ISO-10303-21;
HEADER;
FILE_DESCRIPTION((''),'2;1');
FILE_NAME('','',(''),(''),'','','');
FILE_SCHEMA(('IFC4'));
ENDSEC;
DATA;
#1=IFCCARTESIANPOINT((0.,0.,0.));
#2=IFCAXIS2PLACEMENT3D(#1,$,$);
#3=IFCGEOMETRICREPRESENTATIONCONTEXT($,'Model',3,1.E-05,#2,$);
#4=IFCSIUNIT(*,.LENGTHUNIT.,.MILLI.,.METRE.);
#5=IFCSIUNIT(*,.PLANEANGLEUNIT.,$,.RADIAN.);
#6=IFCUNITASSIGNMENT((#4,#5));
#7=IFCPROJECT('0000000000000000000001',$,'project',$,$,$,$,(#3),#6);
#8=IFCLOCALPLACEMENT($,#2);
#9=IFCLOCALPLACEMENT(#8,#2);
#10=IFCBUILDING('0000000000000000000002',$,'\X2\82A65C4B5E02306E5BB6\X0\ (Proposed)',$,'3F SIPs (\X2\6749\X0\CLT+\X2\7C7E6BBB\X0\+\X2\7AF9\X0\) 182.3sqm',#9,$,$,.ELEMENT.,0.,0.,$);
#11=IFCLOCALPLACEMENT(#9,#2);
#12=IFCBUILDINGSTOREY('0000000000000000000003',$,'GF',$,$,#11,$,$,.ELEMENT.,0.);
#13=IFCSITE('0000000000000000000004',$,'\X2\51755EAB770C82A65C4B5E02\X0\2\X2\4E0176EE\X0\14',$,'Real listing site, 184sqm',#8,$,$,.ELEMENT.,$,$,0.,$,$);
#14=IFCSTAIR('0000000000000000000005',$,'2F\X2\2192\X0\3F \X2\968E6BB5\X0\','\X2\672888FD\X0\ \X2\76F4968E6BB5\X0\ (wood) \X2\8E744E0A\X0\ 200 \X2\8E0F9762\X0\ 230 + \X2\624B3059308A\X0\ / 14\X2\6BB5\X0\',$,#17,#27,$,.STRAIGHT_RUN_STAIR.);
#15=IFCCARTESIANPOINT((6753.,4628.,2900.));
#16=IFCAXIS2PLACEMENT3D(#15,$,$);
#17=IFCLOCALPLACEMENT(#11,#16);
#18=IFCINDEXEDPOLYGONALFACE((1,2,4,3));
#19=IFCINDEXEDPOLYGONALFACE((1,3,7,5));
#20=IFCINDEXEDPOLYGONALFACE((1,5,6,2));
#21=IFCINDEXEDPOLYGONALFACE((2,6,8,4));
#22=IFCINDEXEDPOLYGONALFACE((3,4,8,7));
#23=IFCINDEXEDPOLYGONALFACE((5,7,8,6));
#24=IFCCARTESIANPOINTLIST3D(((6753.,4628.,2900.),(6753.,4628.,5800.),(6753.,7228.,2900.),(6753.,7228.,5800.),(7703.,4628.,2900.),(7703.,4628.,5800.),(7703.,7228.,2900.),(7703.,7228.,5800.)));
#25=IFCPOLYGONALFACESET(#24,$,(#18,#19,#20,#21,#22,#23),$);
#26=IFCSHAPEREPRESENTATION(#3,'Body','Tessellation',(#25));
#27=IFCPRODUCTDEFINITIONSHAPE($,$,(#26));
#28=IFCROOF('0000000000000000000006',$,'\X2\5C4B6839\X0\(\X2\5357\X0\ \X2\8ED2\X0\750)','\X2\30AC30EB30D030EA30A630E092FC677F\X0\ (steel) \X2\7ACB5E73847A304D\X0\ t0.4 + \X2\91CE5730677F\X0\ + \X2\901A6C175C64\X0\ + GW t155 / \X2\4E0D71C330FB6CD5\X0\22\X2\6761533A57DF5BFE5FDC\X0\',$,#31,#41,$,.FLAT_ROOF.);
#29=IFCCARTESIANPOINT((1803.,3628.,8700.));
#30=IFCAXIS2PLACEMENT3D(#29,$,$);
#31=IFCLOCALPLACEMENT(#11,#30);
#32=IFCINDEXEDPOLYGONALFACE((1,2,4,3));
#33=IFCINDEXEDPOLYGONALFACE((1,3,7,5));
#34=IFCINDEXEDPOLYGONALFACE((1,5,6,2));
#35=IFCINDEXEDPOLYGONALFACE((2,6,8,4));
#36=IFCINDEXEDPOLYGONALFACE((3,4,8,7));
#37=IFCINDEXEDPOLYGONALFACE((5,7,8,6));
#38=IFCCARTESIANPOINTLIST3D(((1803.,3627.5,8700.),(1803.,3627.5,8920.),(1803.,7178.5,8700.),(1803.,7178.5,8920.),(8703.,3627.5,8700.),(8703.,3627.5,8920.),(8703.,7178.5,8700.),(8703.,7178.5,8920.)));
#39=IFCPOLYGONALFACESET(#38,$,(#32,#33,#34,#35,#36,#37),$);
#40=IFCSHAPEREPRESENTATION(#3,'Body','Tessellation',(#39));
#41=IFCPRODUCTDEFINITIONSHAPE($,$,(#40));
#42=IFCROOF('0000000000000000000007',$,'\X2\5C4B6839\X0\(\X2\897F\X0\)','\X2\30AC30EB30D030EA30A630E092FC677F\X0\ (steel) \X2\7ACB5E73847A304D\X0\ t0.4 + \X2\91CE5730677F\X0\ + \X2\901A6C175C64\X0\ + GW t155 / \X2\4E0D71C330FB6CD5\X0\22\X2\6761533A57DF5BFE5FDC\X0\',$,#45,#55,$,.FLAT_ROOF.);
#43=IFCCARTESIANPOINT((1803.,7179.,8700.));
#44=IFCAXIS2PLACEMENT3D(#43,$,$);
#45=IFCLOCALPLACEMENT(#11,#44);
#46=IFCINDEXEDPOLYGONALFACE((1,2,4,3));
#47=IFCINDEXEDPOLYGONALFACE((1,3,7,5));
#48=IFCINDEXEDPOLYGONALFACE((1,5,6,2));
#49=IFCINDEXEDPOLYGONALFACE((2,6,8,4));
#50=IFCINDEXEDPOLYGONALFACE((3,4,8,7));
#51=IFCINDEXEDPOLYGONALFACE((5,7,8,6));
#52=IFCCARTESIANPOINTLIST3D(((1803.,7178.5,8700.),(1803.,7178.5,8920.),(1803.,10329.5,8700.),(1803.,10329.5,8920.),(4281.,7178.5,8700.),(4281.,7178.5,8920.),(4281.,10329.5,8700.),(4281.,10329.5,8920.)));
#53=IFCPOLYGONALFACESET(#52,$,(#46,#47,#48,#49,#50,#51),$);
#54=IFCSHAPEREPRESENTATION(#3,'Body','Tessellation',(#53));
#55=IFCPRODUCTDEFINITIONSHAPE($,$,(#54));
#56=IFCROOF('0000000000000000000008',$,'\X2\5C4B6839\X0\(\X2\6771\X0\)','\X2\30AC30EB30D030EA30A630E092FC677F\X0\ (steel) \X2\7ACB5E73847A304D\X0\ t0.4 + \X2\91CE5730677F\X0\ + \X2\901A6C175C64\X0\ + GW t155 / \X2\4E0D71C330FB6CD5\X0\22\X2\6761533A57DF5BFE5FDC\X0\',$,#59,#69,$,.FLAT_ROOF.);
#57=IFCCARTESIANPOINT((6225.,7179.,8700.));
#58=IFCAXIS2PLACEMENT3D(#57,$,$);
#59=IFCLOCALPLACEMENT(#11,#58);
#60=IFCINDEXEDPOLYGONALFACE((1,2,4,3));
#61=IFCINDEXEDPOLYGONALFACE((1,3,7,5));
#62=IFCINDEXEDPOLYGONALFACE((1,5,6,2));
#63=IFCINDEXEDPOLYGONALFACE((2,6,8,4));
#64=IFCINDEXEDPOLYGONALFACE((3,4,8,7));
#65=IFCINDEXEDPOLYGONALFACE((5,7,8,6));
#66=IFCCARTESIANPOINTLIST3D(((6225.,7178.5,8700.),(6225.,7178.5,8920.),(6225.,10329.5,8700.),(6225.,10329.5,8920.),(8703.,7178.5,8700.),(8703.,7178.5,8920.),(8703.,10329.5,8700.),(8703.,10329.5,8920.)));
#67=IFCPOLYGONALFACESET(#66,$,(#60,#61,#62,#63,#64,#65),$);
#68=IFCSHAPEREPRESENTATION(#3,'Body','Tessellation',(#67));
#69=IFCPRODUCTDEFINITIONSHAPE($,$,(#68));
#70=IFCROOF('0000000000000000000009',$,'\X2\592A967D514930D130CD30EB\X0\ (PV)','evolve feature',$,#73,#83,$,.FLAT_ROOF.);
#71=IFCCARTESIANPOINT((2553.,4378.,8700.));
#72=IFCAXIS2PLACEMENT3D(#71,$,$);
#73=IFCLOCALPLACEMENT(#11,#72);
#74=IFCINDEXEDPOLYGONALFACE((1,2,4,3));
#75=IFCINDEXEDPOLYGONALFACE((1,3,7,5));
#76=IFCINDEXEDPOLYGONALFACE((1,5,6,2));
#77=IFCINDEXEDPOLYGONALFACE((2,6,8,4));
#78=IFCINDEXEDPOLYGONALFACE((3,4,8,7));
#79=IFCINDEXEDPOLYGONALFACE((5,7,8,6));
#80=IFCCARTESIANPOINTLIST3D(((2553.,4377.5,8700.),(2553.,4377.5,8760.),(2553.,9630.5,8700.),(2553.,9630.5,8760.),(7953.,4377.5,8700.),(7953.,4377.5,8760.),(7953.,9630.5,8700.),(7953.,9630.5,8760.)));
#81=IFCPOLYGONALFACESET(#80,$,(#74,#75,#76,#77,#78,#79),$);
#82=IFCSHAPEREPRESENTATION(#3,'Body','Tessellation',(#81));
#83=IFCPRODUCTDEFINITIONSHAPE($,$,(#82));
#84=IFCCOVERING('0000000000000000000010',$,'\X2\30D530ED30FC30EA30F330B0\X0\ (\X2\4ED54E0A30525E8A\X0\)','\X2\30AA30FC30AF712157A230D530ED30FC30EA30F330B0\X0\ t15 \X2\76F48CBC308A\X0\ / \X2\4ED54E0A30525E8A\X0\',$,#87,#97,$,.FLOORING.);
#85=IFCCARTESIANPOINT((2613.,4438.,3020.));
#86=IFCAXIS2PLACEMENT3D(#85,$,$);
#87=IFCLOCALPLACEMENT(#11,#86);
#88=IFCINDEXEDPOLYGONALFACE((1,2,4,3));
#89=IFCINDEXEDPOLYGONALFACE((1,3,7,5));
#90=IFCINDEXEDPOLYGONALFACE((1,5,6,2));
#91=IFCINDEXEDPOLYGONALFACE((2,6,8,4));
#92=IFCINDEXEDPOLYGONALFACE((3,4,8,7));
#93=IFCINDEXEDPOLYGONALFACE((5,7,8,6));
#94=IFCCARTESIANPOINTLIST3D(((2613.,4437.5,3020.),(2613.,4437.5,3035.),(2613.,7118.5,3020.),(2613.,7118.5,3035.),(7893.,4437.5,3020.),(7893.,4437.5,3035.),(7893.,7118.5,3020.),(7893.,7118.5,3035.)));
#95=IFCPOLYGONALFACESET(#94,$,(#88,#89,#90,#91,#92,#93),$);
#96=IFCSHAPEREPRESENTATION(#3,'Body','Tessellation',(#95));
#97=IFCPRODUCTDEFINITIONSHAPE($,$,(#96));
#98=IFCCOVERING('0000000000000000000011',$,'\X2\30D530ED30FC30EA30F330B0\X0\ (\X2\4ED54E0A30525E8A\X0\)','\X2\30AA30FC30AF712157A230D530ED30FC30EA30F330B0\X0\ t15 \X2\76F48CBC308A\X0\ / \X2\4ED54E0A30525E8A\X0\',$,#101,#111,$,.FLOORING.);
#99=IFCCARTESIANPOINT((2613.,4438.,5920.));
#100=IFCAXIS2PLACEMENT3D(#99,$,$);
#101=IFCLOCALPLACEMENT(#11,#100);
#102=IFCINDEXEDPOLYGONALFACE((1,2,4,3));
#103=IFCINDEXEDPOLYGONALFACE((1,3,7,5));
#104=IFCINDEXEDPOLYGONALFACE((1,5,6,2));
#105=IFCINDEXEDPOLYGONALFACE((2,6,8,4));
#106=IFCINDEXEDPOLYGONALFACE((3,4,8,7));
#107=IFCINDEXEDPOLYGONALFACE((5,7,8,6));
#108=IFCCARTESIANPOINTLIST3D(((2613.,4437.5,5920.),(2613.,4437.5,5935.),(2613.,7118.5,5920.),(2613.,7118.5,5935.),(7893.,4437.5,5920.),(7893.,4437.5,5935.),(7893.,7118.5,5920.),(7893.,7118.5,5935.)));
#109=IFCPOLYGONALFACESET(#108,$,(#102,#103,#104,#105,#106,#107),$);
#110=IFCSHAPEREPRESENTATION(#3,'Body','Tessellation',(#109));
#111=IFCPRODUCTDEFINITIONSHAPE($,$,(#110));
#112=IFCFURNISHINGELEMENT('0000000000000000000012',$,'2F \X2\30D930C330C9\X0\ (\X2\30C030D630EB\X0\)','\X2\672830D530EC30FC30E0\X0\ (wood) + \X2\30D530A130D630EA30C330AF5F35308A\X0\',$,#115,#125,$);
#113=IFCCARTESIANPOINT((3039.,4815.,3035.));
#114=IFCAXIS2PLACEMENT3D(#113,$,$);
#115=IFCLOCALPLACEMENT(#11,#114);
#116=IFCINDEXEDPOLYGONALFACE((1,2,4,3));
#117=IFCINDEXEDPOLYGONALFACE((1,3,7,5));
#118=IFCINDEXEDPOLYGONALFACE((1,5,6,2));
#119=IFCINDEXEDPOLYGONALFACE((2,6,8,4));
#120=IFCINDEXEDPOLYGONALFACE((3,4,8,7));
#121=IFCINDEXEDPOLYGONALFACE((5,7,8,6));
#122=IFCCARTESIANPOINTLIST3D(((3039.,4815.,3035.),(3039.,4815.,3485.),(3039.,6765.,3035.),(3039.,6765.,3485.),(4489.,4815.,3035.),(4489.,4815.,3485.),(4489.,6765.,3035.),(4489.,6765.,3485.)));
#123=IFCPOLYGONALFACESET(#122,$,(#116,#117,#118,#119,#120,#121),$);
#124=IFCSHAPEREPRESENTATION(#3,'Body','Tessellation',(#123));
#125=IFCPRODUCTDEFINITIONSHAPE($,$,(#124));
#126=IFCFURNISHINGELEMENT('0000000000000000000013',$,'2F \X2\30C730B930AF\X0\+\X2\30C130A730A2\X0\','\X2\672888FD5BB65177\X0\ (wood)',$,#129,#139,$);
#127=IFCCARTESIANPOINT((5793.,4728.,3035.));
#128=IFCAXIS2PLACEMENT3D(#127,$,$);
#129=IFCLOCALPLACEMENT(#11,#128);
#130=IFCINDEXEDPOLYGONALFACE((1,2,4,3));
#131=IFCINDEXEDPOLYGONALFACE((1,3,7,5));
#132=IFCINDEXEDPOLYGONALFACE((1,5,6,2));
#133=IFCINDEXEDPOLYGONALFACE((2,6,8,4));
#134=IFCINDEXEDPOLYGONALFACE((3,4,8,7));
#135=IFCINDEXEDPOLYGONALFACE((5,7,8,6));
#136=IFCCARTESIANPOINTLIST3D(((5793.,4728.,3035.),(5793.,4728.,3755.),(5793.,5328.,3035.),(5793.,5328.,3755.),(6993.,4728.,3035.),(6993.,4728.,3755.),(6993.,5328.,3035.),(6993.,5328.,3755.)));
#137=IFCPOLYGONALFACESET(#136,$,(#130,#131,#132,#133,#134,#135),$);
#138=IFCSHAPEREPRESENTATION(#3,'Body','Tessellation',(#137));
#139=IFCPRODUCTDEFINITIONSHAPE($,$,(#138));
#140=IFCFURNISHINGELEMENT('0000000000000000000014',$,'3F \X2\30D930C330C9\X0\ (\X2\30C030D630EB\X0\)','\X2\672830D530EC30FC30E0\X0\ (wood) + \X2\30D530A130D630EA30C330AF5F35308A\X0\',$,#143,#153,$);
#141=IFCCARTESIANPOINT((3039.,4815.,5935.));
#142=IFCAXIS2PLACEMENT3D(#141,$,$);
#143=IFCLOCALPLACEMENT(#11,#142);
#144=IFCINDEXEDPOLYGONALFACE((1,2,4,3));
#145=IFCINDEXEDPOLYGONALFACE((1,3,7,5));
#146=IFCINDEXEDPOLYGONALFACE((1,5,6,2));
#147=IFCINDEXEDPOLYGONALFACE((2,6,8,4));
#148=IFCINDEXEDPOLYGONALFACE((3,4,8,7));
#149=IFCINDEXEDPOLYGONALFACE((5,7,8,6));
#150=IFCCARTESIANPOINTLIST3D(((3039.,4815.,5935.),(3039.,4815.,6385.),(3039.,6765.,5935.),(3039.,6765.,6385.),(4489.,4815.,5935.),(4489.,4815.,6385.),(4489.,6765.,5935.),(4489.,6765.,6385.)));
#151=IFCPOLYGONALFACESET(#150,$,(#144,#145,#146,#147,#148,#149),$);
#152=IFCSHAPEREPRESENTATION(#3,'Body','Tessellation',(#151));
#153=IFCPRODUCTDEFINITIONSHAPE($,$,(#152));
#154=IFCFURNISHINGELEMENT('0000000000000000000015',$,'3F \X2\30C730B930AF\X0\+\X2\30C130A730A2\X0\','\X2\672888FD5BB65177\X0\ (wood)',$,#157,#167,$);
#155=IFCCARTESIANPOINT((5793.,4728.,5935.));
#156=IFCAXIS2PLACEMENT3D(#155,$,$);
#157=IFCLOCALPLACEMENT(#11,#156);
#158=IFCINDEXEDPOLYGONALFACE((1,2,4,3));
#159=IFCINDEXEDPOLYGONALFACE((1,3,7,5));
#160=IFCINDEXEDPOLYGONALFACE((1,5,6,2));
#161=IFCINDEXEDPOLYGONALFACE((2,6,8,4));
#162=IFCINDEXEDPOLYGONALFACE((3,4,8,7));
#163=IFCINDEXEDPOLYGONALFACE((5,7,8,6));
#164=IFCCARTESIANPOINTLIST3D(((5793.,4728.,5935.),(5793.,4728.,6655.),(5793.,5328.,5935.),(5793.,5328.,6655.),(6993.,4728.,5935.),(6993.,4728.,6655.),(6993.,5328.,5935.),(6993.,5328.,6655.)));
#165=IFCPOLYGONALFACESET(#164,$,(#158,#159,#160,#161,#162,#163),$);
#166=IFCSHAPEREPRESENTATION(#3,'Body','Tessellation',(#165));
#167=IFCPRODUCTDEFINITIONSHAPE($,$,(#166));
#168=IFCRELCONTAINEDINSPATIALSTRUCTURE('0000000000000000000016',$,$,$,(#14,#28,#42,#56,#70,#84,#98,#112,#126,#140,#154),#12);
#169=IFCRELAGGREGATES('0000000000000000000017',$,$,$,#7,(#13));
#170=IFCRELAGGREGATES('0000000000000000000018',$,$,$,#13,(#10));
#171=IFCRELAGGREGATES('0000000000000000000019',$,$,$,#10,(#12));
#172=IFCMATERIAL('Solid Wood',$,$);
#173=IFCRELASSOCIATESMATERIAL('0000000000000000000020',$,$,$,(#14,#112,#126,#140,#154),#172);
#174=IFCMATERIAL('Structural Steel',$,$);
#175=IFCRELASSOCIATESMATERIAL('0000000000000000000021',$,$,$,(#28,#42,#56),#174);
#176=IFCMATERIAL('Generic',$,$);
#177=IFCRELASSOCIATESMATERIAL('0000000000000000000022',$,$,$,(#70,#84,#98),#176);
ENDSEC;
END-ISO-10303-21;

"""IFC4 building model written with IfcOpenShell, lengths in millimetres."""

from ifc_helpers import new_model, si_unit, frame, frame_2d, origin, place, context, project, spatial, rectangle, extrude, material, element, save


model = new_model("IFC4")

# Units and contexts
model_context = context("Model", 3, precision=1e-05, world=origin())
ifc_project = project(units=[si_unit("LENGTHUNIT", "METRE", prefix="MILLI"), si_unit("PLANEANGLEUNIT", "RADIAN")], contexts=[model_context])

# Site, building, storey
site_placement = place(None, origin())
site = spatial("IfcSite", under=ifc_project, at=site_placement, Name="兵庫県芦屋市2丁目14", ObjectType="Real listing site, 184sqm", CompositionType="ELEMENT", RefElevation=0.0)
building_placement = place(site_placement, origin())
building = spatial("IfcBuilding", under=site, at=building_placement, Name="芦屋市の家 (Proposed)", ObjectType="3F SIPs (杉CLT+籾殻+竹) 182.3sqm", CompositionType="ELEMENT", ElevationOfRefHeight=0.0, ElevationOfTerrain=0.0)
storey_placement = place(building_placement, origin())
storey = spatial("IfcBuildingStorey", under=building, at=storey_placement, Name="GF", CompositionType="ELEMENT", Elevation=0.0)

# Shared definitions
ifc_material_1 = material(Name="Solid Wood")

# Stair
stair_placement = place(storey_placement, frame((6753.0, 4628.0, 2900.0)))
element("IfcStair", 1, at=stair_placement, inside=storey, material=ifc_material_1, Name="2F→3F 階段", Description="木製 直階段 (wood) 蹴上 200 踏面 230 + 手すり / 14段", PredefinedType="STRAIGHT_RUN_STAIR", context=model_context, shape_type="SweptSolid", body=[
    extrude(rectangle(XDim=950.0, YDim=2600.0, at=frame_2d((475.0, 1300.0))), frame((6753.0, 4628.0, 2900.0)), (0.0, 0.0, 1.0), 2900.0),
])

# Roofs
ifc_material_2 = material(Name="Structural Steel")
roof_1_placement = place(storey_placement, frame((1803.0, 3628.0, 8700.0)))
element("IfcRoof", 2, at=roof_1_placement, inside=storey, material=ifc_material_2, Name="屋根(南 軒750)", Description="ガルバリウム鋼板 (steel) 立平葺き t0.4 + 野地板 + 通気層 + GW t155 / 不燃・法22条区域対応", PredefinedType="FLAT_ROOF", context=model_context, shape_type="SweptSolid", body=[
    extrude(rectangle(XDim=6900.0, YDim=3551.0, at=frame_2d((3450.0, 1775.0))), frame((1803.0, 3628.0, 8700.0)), (0.0, 0.0, 1.0), 220.0),
])
roof_2_placement = place(storey_placement, frame((1803.0, 7179.0, 8700.0)))
element("IfcRoof", 3, at=roof_2_placement, inside=storey, material=ifc_material_2, Name="屋根(西)", Description="ガルバリウム鋼板 (steel) 立平葺き t0.4 + 野地板 + 通気層 + GW t155 / 不燃・法22条区域対応", PredefinedType="FLAT_ROOF", context=model_context, shape_type="SweptSolid", body=[
    extrude(rectangle(XDim=2478.0, YDim=3151.0, at=frame_2d((1239.0, 1575.0))), frame((1803.0, 7179.0, 8700.0)), (0.0, 0.0, 1.0), 220.0),
])
roof_3_placement = place(storey_placement, frame((6225.0, 7179.0, 8700.0)))
element("IfcRoof", 4, at=roof_3_placement, inside=storey, material=ifc_material_2, Name="屋根(東)", Description="ガルバリウム鋼板 (steel) 立平葺き t0.4 + 野地板 + 通気層 + GW t155 / 不燃・法22条区域対応", PredefinedType="FLAT_ROOF", context=model_context, shape_type="SweptSolid", body=[
    extrude(rectangle(XDim=2478.0, YDim=3151.0, at=frame_2d((1239.0, 1575.0))), frame((6225.0, 7179.0, 8700.0)), (0.0, 0.0, 1.0), 220.0),
])
ifc_material_3 = material(Name="Generic")
roof_4_placement = place(storey_placement, frame((2553.0, 4378.0, 8700.0)))
element("IfcRoof", 5, at=roof_4_placement, inside=storey, material=ifc_material_3, Name="太陽光パネル (PV)", Description="evolve feature", PredefinedType="FLAT_ROOF", context=model_context, shape_type="SweptSolid", body=[
    extrude(rectangle(XDim=5400.0, YDim=5253.0, at=frame_2d((2700.0, 2626.0))), frame((2553.0, 4378.0, 8700.0)), (0.0, 0.0, 1.0), 60.0),
])

# Coverings
covering_1_placement = place(storey_placement, frame((2613.0, 4438.0, 3020.0)))
element("IfcCovering", 6, at=covering_1_placement, inside=storey, material=ifc_material_3, Name="フローリング (仕上げ床)", Description="オーク無垢フローリング t15 直貼り / 仕上げ床", PredefinedType="FLOORING", context=model_context, shape_type="SweptSolid", body=[
    extrude(rectangle(XDim=5280.0, YDim=2681.0, at=frame_2d((2640.0, 1340.0))), frame((2613.0, 4438.0, 3020.0)), (0.0, 0.0, 1.0), 15.0),
])
covering_2_placement = place(storey_placement, frame((2613.0, 4438.0, 5920.0)))
element("IfcCovering", 7, at=covering_2_placement, inside=storey, material=ifc_material_3, Name="フローリング (仕上げ床)", Description="オーク無垢フローリング t15 直貼り / 仕上げ床", PredefinedType="FLOORING", context=model_context, shape_type="SweptSolid", body=[
    extrude(rectangle(XDim=5280.0, YDim=2681.0, at=frame_2d((2640.0, 1340.0))), frame((2613.0, 4438.0, 5920.0)), (0.0, 0.0, 1.0), 15.0),
])

# Furnishing elements
furnishing_1_placement = place(storey_placement, frame((3039.0, 4815.0, 3035.0)))
element("IfcFurnishingElement", 8, at=furnishing_1_placement, inside=storey, material=ifc_material_1, Name="2F ベッド (ダブル)", Description="木フレーム (wood) + ファブリック張り", context=model_context, shape_type="SweptSolid", body=[
    extrude(rectangle(XDim=1450.0, YDim=1950.0, at=frame_2d((725.0, 975.0))), frame((3039.0, 4815.0, 3035.0)), (0.0, 0.0, 1.0), 450.0),
])
furnishing_2_placement = place(storey_placement, frame((5793.0, 4728.0, 3035.0)))
element("IfcFurnishingElement", 9, at=furnishing_2_placement, inside=storey, material=ifc_material_1, Name="2F デスク+チェア", Description="木製家具 (wood)", context=model_context, shape_type="SweptSolid", body=[
    extrude(rectangle(XDim=1200.0, YDim=600.0, at=frame_2d((600.0, 300.0))), frame((5793.0, 4728.0, 3035.0)), (0.0, 0.0, 1.0), 720.0),
])
furnishing_3_placement = place(storey_placement, frame((3039.0, 4815.0, 5935.0)))
element("IfcFurnishingElement", 10, at=furnishing_3_placement, inside=storey, material=ifc_material_1, Name="3F ベッド (ダブル)", Description="木フレーム (wood) + ファブリック張り", context=model_context, shape_type="SweptSolid", body=[
    extrude(rectangle(XDim=1450.0, YDim=1950.0, at=frame_2d((725.0, 975.0))), frame((3039.0, 4815.0, 5935.0)), (0.0, 0.0, 1.0), 450.0),
])
furnishing_4_placement = place(storey_placement, frame((5793.0, 4728.0, 5935.0)))
element("IfcFurnishingElement", 11, at=furnishing_4_placement, inside=storey, material=ifc_material_1, Name="3F デスク+チェア", Description="木製家具 (wood)", context=model_context, shape_type="SweptSolid", body=[
    extrude(rectangle(XDim=1200.0, YDim=600.0, at=frame_2d((600.0, 300.0))), frame((5793.0, 4728.0, 5935.0)), (0.0, 0.0, 1.0), 720.0),
])

save(model, "model.ifc")
